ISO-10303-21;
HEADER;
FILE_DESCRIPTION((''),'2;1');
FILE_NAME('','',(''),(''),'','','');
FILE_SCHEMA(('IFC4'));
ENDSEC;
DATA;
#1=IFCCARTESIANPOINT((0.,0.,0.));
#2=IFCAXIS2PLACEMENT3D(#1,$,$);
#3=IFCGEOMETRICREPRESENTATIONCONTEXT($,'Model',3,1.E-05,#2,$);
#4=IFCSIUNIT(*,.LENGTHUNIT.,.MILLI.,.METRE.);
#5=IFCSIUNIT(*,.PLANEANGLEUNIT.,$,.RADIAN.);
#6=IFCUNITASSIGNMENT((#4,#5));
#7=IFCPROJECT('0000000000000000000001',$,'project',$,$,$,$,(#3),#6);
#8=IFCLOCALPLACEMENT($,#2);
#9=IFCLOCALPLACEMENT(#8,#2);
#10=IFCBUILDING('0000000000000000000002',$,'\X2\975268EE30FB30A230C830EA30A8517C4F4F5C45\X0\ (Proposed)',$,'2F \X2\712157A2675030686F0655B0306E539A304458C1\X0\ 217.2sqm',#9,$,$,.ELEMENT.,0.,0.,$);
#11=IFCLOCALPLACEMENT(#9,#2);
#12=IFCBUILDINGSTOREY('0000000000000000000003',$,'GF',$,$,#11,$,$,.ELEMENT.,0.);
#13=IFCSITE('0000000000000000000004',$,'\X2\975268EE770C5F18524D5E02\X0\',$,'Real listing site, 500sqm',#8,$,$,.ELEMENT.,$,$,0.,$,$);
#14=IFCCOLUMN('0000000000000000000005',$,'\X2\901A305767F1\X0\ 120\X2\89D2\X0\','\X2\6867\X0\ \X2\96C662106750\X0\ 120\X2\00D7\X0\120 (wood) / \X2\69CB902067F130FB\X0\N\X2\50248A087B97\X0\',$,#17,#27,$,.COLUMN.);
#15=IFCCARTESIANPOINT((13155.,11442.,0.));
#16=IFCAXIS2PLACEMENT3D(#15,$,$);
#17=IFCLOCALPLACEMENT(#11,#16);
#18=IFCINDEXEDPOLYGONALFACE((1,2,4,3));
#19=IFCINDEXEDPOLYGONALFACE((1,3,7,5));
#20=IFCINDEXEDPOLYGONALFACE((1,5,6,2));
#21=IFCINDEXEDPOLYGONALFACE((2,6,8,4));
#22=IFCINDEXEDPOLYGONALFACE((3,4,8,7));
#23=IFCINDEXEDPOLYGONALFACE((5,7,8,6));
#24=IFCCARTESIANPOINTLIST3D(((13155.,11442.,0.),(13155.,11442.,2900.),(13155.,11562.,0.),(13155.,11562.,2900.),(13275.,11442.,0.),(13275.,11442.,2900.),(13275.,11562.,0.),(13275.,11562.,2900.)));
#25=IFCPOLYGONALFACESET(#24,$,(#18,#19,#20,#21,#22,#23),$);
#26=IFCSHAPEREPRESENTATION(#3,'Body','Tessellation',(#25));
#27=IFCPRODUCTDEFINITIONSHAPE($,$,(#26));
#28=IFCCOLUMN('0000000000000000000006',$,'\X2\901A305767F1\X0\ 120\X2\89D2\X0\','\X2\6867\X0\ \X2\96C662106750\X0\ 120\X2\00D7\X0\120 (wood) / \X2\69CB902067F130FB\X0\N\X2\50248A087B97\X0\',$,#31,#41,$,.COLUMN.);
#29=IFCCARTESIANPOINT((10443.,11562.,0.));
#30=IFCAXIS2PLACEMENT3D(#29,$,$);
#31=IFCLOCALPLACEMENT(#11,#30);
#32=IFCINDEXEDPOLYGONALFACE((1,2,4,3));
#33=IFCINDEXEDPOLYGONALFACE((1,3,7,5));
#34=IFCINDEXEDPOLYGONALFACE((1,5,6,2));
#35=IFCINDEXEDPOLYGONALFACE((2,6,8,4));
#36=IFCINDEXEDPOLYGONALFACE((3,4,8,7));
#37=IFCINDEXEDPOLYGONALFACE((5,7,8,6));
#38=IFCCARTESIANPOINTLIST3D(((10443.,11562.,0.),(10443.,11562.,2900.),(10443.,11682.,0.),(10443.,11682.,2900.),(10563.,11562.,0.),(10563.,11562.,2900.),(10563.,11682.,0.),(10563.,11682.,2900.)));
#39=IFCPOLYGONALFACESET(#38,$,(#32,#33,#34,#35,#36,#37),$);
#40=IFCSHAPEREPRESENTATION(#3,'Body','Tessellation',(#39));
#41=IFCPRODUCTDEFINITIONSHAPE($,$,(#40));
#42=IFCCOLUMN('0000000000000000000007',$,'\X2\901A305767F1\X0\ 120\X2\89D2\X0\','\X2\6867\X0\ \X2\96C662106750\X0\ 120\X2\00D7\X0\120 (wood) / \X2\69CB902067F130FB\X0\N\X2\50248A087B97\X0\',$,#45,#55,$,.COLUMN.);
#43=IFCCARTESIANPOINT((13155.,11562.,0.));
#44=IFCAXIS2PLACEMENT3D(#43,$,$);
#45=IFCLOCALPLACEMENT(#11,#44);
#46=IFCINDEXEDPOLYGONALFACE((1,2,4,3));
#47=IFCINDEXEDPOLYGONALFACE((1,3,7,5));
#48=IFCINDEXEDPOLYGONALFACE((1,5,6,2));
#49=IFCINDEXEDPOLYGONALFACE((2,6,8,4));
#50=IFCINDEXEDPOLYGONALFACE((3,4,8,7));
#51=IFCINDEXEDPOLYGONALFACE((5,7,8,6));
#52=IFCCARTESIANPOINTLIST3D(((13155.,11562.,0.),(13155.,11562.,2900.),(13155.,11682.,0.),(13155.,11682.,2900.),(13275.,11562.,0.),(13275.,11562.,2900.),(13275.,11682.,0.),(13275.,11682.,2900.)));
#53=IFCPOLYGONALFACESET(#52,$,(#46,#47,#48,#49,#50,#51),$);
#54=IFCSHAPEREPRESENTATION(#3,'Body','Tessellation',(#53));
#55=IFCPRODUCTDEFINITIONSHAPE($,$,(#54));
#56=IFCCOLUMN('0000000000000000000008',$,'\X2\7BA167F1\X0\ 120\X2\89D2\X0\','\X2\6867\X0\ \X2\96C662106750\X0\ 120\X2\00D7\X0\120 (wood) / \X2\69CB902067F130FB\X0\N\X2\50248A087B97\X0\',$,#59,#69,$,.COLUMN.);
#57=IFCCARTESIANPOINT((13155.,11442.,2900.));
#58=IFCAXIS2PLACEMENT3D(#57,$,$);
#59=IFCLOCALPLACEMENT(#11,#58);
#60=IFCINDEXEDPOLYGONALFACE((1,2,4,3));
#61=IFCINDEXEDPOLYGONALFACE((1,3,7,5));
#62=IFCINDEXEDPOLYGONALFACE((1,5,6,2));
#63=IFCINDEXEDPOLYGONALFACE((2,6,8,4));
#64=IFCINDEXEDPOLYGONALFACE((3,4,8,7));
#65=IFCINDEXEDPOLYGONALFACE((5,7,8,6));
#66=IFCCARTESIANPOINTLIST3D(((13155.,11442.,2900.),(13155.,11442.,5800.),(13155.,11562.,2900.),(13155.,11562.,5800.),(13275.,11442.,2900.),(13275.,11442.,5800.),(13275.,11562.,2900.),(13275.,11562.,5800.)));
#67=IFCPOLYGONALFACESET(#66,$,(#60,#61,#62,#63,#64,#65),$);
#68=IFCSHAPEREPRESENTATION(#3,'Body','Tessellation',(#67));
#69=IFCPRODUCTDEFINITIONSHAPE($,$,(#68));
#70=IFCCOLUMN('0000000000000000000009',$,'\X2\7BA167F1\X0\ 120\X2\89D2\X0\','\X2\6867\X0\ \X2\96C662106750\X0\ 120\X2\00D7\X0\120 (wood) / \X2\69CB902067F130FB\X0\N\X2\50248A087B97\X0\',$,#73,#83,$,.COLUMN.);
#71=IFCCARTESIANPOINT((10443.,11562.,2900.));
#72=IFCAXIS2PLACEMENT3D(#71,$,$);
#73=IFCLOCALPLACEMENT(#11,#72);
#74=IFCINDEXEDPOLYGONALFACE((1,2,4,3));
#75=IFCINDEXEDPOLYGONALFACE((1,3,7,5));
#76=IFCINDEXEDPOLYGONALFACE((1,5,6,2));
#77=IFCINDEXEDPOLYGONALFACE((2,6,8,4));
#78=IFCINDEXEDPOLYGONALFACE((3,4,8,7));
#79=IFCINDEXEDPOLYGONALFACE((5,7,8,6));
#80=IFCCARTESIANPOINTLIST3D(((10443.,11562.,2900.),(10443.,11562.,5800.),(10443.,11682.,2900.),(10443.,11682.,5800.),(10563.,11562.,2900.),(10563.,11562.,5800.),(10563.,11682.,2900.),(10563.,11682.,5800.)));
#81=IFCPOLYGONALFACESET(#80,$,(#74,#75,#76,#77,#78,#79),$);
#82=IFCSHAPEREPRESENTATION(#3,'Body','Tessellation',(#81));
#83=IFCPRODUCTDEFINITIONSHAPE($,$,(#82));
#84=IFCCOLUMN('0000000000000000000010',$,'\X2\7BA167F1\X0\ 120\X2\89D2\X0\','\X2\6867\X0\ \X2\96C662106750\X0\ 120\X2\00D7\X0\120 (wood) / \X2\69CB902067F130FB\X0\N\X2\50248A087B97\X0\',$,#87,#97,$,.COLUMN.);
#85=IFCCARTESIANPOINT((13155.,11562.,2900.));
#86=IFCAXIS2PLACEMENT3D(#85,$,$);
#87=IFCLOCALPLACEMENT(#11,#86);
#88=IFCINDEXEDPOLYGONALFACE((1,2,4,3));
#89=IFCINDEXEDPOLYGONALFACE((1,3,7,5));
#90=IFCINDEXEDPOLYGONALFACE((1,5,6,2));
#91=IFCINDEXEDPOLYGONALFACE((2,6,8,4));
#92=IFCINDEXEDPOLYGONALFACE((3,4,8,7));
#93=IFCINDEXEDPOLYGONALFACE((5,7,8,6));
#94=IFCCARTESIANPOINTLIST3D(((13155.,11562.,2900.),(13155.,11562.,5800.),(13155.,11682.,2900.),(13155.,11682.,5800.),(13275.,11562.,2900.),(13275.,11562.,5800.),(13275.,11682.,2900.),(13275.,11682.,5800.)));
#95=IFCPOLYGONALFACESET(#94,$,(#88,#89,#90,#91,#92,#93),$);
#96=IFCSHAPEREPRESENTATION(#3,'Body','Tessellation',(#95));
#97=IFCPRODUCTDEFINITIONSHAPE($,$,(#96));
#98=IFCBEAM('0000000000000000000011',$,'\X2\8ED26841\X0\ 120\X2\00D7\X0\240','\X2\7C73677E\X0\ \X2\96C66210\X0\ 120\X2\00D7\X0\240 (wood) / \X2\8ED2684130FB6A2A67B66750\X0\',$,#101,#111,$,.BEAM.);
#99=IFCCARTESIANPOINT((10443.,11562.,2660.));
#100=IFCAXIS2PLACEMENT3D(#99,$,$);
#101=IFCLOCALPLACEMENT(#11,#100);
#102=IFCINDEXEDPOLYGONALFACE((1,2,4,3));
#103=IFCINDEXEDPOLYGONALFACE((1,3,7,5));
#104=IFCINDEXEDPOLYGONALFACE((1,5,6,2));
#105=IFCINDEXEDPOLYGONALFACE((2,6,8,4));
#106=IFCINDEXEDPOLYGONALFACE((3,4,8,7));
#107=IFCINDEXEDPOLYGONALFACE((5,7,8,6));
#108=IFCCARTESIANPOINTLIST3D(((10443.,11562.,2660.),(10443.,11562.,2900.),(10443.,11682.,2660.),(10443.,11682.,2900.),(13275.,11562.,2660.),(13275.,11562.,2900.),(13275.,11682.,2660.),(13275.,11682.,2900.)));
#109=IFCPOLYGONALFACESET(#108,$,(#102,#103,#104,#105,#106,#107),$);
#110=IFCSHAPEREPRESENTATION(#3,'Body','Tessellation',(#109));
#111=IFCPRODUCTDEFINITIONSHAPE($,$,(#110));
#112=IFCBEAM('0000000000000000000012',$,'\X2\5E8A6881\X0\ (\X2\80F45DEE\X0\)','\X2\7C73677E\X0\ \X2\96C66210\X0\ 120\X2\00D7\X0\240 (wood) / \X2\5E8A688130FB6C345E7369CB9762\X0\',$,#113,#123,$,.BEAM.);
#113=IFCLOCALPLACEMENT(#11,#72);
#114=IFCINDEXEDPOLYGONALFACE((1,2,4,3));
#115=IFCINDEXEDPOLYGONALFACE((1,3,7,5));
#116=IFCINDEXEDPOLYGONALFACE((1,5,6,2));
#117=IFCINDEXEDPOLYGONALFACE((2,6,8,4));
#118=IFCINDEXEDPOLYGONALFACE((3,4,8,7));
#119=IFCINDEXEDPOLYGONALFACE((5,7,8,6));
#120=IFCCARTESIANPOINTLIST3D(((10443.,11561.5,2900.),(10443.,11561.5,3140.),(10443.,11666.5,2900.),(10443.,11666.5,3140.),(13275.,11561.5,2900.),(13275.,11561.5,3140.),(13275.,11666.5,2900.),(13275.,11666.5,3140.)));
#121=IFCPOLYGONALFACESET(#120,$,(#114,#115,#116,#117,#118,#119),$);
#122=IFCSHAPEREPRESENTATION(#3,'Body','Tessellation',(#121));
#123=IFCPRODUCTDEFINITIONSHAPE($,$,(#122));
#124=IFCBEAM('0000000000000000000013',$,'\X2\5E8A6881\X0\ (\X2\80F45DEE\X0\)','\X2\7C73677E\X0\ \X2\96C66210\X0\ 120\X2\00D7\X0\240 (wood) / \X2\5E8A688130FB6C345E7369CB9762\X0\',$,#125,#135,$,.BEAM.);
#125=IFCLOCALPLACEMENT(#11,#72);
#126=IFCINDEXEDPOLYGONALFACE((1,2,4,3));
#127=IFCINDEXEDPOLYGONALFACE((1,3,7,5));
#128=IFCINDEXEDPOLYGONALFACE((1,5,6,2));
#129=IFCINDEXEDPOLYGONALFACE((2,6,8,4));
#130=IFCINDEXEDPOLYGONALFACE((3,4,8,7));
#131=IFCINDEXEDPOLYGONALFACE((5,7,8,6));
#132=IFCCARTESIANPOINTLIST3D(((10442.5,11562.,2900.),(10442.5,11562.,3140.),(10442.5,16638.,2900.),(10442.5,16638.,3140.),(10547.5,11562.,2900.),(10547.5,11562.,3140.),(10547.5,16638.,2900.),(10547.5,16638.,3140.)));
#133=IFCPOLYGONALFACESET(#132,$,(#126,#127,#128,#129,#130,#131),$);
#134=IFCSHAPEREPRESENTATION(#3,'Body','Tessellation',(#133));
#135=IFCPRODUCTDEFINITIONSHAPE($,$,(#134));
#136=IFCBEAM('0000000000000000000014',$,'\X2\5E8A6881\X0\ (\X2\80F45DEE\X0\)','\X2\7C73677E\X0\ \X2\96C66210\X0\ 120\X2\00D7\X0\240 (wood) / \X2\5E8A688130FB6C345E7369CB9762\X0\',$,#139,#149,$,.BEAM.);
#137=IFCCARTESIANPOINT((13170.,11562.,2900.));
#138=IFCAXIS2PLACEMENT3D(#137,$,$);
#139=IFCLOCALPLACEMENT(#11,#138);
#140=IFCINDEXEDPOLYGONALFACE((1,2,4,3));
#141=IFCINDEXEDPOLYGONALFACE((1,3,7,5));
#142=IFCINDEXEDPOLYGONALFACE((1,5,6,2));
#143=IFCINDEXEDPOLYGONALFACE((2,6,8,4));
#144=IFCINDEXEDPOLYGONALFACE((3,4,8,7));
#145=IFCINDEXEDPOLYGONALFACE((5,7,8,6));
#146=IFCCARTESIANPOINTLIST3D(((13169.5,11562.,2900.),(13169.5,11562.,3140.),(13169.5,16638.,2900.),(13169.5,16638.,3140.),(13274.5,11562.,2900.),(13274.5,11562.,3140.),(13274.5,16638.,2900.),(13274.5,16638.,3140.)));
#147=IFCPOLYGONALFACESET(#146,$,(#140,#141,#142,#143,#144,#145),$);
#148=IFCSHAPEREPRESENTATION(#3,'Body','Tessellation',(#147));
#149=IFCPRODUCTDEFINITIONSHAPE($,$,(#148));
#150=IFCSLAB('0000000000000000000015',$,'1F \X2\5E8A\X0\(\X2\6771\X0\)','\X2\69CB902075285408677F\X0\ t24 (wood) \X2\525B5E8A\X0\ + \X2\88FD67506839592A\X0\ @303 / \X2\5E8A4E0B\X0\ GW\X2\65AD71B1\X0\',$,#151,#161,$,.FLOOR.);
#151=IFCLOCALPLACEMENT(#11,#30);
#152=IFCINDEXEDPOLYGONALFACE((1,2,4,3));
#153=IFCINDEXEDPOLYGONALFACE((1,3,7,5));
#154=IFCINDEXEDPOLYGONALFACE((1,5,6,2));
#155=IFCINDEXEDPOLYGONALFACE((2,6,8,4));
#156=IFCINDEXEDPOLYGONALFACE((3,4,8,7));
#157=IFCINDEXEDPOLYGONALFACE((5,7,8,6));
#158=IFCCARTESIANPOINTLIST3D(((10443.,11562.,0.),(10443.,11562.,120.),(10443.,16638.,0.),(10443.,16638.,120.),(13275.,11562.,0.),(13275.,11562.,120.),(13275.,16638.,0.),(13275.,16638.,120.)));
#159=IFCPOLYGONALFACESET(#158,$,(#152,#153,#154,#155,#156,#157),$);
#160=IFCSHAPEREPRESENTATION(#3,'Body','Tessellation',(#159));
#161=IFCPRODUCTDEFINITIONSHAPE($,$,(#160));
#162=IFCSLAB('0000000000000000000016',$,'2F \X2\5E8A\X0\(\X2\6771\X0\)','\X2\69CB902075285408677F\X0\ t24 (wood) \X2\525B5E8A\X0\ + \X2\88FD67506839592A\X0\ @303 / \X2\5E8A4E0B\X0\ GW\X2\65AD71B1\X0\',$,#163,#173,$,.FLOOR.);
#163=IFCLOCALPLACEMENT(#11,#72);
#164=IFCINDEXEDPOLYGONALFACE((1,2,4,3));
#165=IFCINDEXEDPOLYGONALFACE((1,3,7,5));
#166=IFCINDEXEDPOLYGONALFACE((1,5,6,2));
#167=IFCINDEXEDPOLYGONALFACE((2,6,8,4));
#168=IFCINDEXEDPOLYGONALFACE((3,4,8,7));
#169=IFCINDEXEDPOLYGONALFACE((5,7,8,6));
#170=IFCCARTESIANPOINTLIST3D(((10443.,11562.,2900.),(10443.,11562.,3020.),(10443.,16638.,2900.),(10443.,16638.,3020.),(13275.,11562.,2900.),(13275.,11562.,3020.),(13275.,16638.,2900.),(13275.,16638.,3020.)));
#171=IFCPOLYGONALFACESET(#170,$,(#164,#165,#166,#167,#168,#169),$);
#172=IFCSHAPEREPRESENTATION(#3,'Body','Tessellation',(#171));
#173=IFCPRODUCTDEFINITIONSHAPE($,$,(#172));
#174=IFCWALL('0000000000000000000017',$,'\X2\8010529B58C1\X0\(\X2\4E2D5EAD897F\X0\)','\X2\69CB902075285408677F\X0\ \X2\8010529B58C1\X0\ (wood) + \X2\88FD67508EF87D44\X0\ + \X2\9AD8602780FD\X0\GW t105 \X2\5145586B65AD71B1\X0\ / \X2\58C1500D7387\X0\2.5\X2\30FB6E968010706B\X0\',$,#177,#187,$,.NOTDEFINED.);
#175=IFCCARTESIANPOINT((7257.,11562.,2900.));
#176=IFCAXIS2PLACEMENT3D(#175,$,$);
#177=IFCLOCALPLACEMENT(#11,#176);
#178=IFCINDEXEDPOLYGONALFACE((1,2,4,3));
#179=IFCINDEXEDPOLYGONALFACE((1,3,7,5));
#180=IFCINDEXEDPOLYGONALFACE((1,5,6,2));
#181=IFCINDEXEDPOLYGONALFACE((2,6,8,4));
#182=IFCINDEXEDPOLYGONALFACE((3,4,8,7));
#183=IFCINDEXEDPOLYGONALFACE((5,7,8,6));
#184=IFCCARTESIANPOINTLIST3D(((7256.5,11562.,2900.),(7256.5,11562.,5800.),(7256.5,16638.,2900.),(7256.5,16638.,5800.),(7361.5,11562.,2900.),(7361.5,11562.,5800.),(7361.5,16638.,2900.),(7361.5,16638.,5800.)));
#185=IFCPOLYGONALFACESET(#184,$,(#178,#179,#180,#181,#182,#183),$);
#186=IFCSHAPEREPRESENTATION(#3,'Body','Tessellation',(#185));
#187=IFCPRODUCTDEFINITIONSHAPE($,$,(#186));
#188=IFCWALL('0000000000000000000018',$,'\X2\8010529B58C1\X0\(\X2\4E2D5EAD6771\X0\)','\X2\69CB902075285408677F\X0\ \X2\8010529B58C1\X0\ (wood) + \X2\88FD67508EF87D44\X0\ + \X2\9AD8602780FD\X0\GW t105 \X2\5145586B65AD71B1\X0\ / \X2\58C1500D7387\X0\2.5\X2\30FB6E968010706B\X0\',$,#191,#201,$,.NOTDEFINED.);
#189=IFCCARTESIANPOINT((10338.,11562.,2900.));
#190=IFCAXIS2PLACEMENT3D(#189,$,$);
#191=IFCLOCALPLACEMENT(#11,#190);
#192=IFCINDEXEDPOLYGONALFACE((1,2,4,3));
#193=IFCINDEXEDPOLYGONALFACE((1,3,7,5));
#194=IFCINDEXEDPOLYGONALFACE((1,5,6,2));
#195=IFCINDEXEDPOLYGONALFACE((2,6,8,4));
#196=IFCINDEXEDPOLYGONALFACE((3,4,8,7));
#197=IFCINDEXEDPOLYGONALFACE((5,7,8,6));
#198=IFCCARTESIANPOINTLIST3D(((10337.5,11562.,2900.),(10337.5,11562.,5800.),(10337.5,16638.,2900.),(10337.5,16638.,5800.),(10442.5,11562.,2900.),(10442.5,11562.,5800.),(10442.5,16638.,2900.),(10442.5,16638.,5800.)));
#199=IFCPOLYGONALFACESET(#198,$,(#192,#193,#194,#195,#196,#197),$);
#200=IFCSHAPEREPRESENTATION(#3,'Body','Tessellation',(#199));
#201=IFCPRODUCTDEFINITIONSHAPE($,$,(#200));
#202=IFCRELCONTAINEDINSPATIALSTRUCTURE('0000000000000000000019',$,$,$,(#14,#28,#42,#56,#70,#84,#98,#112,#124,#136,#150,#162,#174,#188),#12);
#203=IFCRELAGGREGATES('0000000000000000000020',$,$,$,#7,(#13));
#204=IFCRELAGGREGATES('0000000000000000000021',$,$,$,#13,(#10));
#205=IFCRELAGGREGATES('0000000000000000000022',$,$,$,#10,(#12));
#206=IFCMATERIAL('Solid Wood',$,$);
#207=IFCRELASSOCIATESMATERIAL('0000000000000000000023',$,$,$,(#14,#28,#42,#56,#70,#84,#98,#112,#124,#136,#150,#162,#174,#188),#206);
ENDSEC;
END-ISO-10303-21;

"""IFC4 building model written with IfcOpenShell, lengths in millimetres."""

from ifc_helpers import new_model, si_unit, frame, frame_2d, origin, place, context, project, spatial, rectangle, extrude, material, element, save


model = new_model("IFC4")

# Units and contexts
model_context = context("Model", 3, precision=1e-05, world=origin())
ifc_project = project(units=[si_unit("LENGTHUNIT", "METRE", prefix="MILLI"), si_unit("PLANEANGLEUNIT", "RADIAN")], contexts=[model_context])

# Site, building, storey
site_placement = place(None, origin())
site = spatial("IfcSite", under=ifc_project, at=site_placement, Name="青森県弘前市", ObjectType="Real listing site, 500sqm", CompositionType="ELEMENT", RefElevation=0.0)
building_placement = place(site_placement, origin())
building = spatial("IfcBuilding", under=site, at=building_placement, Name="青森・アトリエ兼住居 (Proposed)", ObjectType="2F 無垢材と漆喰の厚い壁 217.2sqm", CompositionType="ELEMENT", ElevationOfRefHeight=0.0, ElevationOfTerrain=0.0)
storey_placement = place(building_placement, origin())
storey = spatial("IfcBuildingStorey", under=building, at=storey_placement, Name="GF", CompositionType="ELEMENT", Elevation=0.0)

# Columns
ifc_material_1 = material(Name="Solid Wood")
column_1_placement = place(storey_placement, frame((13155.0, 11442.0, 0.0)))
element("IfcColumn", 1, at=column_1_placement, inside=storey, material=ifc_material_1, Name="通し柱 120角", Description="桧 集成材 120×120 (wood) / 構造柱・N値計算", PredefinedType="COLUMN", context=model_context, shape_type="SweptSolid", body=[
    extrude(rectangle(XDim=120.0, YDim=120.0, at=frame_2d((60.0, 60.0))), frame((13155.0, 11442.0, 0.0)), (0.0, 0.0, 1.0), 2900.0),
])
column_2_placement = place(storey_placement, frame((10443.0, 11562.0, 0.0)))
element("IfcColumn", 2, at=column_2_placement, inside=storey, material=ifc_material_1, Name="通し柱 120角", Description="桧 集成材 120×120 (wood) / 構造柱・N値計算", PredefinedType="COLUMN", context=model_context, shape_type="SweptSolid", body=[
    extrude(rectangle(XDim=120.0, YDim=120.0, at=frame_2d((60.0, 60.0))), frame((10443.0, 11562.0, 0.0)), (0.0, 0.0, 1.0), 2900.0),
])
column_3_placement = place(storey_placement, frame((13155.0, 11562.0, 0.0)))
element("IfcColumn", 3, at=column_3_placement, inside=storey, material=ifc_material_1, Name="通し柱 120角", Description="桧 集成材 120×120 (wood) / 構造柱・N値計算", PredefinedType="COLUMN", context=model_context, shape_type="SweptSolid", body=[
    extrude(rectangle(XDim=120.0, YDim=120.0, at=frame_2d((60.0, 60.0))), frame((13155.0, 11562.0, 0.0)), (0.0, 0.0, 1.0), 2900.0),
])
column_4_placement = place(storey_placement, frame((13155.0, 11442.0, 2900.0)))
element("IfcColumn", 4, at=column_4_placement, inside=storey, material=ifc_material_1, Name="管柱 120角", Description="桧 集成材 120×120 (wood) / 構造柱・N値計算", PredefinedType="COLUMN", context=model_context, shape_type="SweptSolid", body=[
    extrude(rectangle(XDim=120.0, YDim=120.0, at=frame_2d((60.0, 60.0))), frame((13155.0, 11442.0, 2900.0)), (0.0, 0.0, 1.0), 2900.0),
])
column_5_placement = place(storey_placement, frame((10443.0, 11562.0, 2900.0)))
element("IfcColumn", 5, at=column_5_placement, inside=storey, material=ifc_material_1, Name="管柱 120角", Description="桧 集成材 120×120 (wood) / 構造柱・N値計算", PredefinedType="COLUMN", context=model_context, shape_type="SweptSolid", body=[
    extrude(rectangle(XDim=120.0, YDim=120.0, at=frame_2d((60.0, 60.0))), frame((10443.0, 11562.0, 2900.0)), (0.0, 0.0, 1.0), 2900.0),
])
column_6_placement = place(storey_placement, frame((13155.0, 11562.0, 2900.0)))
element("IfcColumn", 6, at=column_6_placement, inside=storey, material=ifc_material_1, Name="管柱 120角", Description="桧 集成材 120×120 (wood) / 構造柱・N値計算", PredefinedType="COLUMN", context=model_context, shape_type="SweptSolid", body=[
    extrude(rectangle(XDim=120.0, YDim=120.0, at=frame_2d((60.0, 60.0))), frame((13155.0, 11562.0, 2900.0)), (0.0, 0.0, 1.0), 2900.0),
])

# Beams
beam_1_placement = place(storey_placement, frame((10443.0, 11562.0, 2660.0)))
element("IfcBeam", 7, at=beam_1_placement, inside=storey, material=ifc_material_1, Name="軒桁 120×240", Description="米松 集成 120×240 (wood) / 軒桁・横架材", PredefinedType="BEAM", context=model_context, shape_type="SweptSolid", body=[
    extrude(rectangle(XDim=2832.0, YDim=120.0, at=frame_2d((1416.0, 60.0))), frame((10443.0, 11562.0, 2660.0)), (0.0, 0.0, 1.0), 240.0),
])
beam_2_placement = place(storey_placement, frame((10443.0, 11562.0, 2900.0)))
element("IfcBeam", 8, at=beam_2_placement, inside=storey, material=ifc_material_1, Name="床梁 (胴差)", Description="米松 集成 120×240 (wood) / 床梁・水平構面", PredefinedType="BEAM", context=model_context, shape_type="SweptSolid", body=[
    extrude(rectangle(XDim=2832.0, YDim=105.0, at=frame_2d((1416.0, 52.0))), frame((10443.0, 11562.0, 2900.0)), (0.0, 0.0, 1.0), 240.0),
])
beam_3_placement = place(storey_placement, frame((10443.0, 11562.0, 2900.0)))
element("IfcBeam", 9, at=beam_3_placement, inside=storey, material=ifc_material_1, Name="床梁 (胴差)", Description="米松 集成 120×240 (wood) / 床梁・水平構面", PredefinedType="BEAM", context=model_context, shape_type="SweptSolid", body=[
    extrude(rectangle(XDim=105.0, YDim=5076.0, at=frame_2d((52.0, 2538.0))), frame((10443.0, 11562.0, 2900.0)), (0.0, 0.0, 1.0), 240.0),
])
beam_4_placement = place(storey_placement, frame((13170.0, 11562.0, 2900.0)))
element("IfcBeam", 10, at=beam_4_placement, inside=storey, material=ifc_material_1, Name="床梁 (胴差)", Description="米松 集成 120×240 (wood) / 床梁・水平構面", PredefinedType="BEAM", context=model_context, shape_type="SweptSolid", body=[
    extrude(rectangle(XDim=105.0, YDim=5076.0, at=frame_2d((52.0, 2538.0))), frame((13170.0, 11562.0, 2900.0)), (0.0, 0.0, 1.0), 240.0),
])

# Slabs
slab_1_placement = place(storey_placement, frame((10443.0, 11562.0, 0.0)))
element("IfcSlab", 11, at=slab_1_placement, inside=storey, material=ifc_material_1, Name="1F 床(東)", Description="構造用合板 t24 (wood) 剛床 + 製材根太 @303 / 床下 GW断熱", PredefinedType="FLOOR", context=model_context, shape_type="SweptSolid", body=[
    extrude(rectangle(XDim=2832.0, YDim=5076.0, at=frame_2d((1416.0, 2538.0))), frame((10443.0, 11562.0, 0.0)), (0.0, 0.0, 1.0), 120.0),
])
slab_2_placement = place(storey_placement, frame((10443.0, 11562.0, 2900.0)))
element("IfcSlab", 12, at=slab_2_placement, inside=storey, material=ifc_material_1, Name="2F 床(東)", Description="構造用合板 t24 (wood) 剛床 + 製材根太 @303 / 床下 GW断熱", PredefinedType="FLOOR", context=model_context, shape_type="SweptSolid", body=[
    extrude(rectangle(XDim=2832.0, YDim=5076.0, at=frame_2d((1416.0, 2538.0))), frame((10443.0, 11562.0, 2900.0)), (0.0, 0.0, 1.0), 120.0),
])

# Walls
wall_1_placement = place(storey_placement, frame((7257.0, 11562.0, 2900.0)))
element("IfcWall", 13, at=wall_1_placement, inside=storey, material=ifc_material_1, Name="耐力壁(中庭西)", Description="構造用合板 耐力壁 (wood) + 製材軸組 + 高性能GW t105 充填断熱 / 壁倍率2.5・準耐火", PredefinedType="NOTDEFINED", context=model_context, shape_type="SweptSolid", body=[
    extrude(rectangle(XDim=105.0, YDim=5076.0, at=frame_2d((52.0, 2538.0))), frame((7257.0, 11562.0, 2900.0)), (0.0, 0.0, 1.0), 2900.0),
])
wall_2_placement = place(storey_placement, frame((10338.0, 11562.0, 2900.0)))
element("IfcWall", 14, at=wall_2_placement, inside=storey, material=ifc_material_1, Name="耐力壁(中庭東)", Description="構造用合板 耐力壁 (wood) + 製材軸組 + 高性能GW t105 充填断熱 / 壁倍率2.5・準耐火", PredefinedType="NOTDEFINED", context=model_context, shape_type="SweptSolid", body=[
    extrude(rectangle(XDim=105.0, YDim=5076.0, at=frame_2d((52.0, 2538.0))), frame((10338.0, 11562.0, 2900.0)), (0.0, 0.0, 1.0), 2900.0),
])

save(model, "model.ifc")
